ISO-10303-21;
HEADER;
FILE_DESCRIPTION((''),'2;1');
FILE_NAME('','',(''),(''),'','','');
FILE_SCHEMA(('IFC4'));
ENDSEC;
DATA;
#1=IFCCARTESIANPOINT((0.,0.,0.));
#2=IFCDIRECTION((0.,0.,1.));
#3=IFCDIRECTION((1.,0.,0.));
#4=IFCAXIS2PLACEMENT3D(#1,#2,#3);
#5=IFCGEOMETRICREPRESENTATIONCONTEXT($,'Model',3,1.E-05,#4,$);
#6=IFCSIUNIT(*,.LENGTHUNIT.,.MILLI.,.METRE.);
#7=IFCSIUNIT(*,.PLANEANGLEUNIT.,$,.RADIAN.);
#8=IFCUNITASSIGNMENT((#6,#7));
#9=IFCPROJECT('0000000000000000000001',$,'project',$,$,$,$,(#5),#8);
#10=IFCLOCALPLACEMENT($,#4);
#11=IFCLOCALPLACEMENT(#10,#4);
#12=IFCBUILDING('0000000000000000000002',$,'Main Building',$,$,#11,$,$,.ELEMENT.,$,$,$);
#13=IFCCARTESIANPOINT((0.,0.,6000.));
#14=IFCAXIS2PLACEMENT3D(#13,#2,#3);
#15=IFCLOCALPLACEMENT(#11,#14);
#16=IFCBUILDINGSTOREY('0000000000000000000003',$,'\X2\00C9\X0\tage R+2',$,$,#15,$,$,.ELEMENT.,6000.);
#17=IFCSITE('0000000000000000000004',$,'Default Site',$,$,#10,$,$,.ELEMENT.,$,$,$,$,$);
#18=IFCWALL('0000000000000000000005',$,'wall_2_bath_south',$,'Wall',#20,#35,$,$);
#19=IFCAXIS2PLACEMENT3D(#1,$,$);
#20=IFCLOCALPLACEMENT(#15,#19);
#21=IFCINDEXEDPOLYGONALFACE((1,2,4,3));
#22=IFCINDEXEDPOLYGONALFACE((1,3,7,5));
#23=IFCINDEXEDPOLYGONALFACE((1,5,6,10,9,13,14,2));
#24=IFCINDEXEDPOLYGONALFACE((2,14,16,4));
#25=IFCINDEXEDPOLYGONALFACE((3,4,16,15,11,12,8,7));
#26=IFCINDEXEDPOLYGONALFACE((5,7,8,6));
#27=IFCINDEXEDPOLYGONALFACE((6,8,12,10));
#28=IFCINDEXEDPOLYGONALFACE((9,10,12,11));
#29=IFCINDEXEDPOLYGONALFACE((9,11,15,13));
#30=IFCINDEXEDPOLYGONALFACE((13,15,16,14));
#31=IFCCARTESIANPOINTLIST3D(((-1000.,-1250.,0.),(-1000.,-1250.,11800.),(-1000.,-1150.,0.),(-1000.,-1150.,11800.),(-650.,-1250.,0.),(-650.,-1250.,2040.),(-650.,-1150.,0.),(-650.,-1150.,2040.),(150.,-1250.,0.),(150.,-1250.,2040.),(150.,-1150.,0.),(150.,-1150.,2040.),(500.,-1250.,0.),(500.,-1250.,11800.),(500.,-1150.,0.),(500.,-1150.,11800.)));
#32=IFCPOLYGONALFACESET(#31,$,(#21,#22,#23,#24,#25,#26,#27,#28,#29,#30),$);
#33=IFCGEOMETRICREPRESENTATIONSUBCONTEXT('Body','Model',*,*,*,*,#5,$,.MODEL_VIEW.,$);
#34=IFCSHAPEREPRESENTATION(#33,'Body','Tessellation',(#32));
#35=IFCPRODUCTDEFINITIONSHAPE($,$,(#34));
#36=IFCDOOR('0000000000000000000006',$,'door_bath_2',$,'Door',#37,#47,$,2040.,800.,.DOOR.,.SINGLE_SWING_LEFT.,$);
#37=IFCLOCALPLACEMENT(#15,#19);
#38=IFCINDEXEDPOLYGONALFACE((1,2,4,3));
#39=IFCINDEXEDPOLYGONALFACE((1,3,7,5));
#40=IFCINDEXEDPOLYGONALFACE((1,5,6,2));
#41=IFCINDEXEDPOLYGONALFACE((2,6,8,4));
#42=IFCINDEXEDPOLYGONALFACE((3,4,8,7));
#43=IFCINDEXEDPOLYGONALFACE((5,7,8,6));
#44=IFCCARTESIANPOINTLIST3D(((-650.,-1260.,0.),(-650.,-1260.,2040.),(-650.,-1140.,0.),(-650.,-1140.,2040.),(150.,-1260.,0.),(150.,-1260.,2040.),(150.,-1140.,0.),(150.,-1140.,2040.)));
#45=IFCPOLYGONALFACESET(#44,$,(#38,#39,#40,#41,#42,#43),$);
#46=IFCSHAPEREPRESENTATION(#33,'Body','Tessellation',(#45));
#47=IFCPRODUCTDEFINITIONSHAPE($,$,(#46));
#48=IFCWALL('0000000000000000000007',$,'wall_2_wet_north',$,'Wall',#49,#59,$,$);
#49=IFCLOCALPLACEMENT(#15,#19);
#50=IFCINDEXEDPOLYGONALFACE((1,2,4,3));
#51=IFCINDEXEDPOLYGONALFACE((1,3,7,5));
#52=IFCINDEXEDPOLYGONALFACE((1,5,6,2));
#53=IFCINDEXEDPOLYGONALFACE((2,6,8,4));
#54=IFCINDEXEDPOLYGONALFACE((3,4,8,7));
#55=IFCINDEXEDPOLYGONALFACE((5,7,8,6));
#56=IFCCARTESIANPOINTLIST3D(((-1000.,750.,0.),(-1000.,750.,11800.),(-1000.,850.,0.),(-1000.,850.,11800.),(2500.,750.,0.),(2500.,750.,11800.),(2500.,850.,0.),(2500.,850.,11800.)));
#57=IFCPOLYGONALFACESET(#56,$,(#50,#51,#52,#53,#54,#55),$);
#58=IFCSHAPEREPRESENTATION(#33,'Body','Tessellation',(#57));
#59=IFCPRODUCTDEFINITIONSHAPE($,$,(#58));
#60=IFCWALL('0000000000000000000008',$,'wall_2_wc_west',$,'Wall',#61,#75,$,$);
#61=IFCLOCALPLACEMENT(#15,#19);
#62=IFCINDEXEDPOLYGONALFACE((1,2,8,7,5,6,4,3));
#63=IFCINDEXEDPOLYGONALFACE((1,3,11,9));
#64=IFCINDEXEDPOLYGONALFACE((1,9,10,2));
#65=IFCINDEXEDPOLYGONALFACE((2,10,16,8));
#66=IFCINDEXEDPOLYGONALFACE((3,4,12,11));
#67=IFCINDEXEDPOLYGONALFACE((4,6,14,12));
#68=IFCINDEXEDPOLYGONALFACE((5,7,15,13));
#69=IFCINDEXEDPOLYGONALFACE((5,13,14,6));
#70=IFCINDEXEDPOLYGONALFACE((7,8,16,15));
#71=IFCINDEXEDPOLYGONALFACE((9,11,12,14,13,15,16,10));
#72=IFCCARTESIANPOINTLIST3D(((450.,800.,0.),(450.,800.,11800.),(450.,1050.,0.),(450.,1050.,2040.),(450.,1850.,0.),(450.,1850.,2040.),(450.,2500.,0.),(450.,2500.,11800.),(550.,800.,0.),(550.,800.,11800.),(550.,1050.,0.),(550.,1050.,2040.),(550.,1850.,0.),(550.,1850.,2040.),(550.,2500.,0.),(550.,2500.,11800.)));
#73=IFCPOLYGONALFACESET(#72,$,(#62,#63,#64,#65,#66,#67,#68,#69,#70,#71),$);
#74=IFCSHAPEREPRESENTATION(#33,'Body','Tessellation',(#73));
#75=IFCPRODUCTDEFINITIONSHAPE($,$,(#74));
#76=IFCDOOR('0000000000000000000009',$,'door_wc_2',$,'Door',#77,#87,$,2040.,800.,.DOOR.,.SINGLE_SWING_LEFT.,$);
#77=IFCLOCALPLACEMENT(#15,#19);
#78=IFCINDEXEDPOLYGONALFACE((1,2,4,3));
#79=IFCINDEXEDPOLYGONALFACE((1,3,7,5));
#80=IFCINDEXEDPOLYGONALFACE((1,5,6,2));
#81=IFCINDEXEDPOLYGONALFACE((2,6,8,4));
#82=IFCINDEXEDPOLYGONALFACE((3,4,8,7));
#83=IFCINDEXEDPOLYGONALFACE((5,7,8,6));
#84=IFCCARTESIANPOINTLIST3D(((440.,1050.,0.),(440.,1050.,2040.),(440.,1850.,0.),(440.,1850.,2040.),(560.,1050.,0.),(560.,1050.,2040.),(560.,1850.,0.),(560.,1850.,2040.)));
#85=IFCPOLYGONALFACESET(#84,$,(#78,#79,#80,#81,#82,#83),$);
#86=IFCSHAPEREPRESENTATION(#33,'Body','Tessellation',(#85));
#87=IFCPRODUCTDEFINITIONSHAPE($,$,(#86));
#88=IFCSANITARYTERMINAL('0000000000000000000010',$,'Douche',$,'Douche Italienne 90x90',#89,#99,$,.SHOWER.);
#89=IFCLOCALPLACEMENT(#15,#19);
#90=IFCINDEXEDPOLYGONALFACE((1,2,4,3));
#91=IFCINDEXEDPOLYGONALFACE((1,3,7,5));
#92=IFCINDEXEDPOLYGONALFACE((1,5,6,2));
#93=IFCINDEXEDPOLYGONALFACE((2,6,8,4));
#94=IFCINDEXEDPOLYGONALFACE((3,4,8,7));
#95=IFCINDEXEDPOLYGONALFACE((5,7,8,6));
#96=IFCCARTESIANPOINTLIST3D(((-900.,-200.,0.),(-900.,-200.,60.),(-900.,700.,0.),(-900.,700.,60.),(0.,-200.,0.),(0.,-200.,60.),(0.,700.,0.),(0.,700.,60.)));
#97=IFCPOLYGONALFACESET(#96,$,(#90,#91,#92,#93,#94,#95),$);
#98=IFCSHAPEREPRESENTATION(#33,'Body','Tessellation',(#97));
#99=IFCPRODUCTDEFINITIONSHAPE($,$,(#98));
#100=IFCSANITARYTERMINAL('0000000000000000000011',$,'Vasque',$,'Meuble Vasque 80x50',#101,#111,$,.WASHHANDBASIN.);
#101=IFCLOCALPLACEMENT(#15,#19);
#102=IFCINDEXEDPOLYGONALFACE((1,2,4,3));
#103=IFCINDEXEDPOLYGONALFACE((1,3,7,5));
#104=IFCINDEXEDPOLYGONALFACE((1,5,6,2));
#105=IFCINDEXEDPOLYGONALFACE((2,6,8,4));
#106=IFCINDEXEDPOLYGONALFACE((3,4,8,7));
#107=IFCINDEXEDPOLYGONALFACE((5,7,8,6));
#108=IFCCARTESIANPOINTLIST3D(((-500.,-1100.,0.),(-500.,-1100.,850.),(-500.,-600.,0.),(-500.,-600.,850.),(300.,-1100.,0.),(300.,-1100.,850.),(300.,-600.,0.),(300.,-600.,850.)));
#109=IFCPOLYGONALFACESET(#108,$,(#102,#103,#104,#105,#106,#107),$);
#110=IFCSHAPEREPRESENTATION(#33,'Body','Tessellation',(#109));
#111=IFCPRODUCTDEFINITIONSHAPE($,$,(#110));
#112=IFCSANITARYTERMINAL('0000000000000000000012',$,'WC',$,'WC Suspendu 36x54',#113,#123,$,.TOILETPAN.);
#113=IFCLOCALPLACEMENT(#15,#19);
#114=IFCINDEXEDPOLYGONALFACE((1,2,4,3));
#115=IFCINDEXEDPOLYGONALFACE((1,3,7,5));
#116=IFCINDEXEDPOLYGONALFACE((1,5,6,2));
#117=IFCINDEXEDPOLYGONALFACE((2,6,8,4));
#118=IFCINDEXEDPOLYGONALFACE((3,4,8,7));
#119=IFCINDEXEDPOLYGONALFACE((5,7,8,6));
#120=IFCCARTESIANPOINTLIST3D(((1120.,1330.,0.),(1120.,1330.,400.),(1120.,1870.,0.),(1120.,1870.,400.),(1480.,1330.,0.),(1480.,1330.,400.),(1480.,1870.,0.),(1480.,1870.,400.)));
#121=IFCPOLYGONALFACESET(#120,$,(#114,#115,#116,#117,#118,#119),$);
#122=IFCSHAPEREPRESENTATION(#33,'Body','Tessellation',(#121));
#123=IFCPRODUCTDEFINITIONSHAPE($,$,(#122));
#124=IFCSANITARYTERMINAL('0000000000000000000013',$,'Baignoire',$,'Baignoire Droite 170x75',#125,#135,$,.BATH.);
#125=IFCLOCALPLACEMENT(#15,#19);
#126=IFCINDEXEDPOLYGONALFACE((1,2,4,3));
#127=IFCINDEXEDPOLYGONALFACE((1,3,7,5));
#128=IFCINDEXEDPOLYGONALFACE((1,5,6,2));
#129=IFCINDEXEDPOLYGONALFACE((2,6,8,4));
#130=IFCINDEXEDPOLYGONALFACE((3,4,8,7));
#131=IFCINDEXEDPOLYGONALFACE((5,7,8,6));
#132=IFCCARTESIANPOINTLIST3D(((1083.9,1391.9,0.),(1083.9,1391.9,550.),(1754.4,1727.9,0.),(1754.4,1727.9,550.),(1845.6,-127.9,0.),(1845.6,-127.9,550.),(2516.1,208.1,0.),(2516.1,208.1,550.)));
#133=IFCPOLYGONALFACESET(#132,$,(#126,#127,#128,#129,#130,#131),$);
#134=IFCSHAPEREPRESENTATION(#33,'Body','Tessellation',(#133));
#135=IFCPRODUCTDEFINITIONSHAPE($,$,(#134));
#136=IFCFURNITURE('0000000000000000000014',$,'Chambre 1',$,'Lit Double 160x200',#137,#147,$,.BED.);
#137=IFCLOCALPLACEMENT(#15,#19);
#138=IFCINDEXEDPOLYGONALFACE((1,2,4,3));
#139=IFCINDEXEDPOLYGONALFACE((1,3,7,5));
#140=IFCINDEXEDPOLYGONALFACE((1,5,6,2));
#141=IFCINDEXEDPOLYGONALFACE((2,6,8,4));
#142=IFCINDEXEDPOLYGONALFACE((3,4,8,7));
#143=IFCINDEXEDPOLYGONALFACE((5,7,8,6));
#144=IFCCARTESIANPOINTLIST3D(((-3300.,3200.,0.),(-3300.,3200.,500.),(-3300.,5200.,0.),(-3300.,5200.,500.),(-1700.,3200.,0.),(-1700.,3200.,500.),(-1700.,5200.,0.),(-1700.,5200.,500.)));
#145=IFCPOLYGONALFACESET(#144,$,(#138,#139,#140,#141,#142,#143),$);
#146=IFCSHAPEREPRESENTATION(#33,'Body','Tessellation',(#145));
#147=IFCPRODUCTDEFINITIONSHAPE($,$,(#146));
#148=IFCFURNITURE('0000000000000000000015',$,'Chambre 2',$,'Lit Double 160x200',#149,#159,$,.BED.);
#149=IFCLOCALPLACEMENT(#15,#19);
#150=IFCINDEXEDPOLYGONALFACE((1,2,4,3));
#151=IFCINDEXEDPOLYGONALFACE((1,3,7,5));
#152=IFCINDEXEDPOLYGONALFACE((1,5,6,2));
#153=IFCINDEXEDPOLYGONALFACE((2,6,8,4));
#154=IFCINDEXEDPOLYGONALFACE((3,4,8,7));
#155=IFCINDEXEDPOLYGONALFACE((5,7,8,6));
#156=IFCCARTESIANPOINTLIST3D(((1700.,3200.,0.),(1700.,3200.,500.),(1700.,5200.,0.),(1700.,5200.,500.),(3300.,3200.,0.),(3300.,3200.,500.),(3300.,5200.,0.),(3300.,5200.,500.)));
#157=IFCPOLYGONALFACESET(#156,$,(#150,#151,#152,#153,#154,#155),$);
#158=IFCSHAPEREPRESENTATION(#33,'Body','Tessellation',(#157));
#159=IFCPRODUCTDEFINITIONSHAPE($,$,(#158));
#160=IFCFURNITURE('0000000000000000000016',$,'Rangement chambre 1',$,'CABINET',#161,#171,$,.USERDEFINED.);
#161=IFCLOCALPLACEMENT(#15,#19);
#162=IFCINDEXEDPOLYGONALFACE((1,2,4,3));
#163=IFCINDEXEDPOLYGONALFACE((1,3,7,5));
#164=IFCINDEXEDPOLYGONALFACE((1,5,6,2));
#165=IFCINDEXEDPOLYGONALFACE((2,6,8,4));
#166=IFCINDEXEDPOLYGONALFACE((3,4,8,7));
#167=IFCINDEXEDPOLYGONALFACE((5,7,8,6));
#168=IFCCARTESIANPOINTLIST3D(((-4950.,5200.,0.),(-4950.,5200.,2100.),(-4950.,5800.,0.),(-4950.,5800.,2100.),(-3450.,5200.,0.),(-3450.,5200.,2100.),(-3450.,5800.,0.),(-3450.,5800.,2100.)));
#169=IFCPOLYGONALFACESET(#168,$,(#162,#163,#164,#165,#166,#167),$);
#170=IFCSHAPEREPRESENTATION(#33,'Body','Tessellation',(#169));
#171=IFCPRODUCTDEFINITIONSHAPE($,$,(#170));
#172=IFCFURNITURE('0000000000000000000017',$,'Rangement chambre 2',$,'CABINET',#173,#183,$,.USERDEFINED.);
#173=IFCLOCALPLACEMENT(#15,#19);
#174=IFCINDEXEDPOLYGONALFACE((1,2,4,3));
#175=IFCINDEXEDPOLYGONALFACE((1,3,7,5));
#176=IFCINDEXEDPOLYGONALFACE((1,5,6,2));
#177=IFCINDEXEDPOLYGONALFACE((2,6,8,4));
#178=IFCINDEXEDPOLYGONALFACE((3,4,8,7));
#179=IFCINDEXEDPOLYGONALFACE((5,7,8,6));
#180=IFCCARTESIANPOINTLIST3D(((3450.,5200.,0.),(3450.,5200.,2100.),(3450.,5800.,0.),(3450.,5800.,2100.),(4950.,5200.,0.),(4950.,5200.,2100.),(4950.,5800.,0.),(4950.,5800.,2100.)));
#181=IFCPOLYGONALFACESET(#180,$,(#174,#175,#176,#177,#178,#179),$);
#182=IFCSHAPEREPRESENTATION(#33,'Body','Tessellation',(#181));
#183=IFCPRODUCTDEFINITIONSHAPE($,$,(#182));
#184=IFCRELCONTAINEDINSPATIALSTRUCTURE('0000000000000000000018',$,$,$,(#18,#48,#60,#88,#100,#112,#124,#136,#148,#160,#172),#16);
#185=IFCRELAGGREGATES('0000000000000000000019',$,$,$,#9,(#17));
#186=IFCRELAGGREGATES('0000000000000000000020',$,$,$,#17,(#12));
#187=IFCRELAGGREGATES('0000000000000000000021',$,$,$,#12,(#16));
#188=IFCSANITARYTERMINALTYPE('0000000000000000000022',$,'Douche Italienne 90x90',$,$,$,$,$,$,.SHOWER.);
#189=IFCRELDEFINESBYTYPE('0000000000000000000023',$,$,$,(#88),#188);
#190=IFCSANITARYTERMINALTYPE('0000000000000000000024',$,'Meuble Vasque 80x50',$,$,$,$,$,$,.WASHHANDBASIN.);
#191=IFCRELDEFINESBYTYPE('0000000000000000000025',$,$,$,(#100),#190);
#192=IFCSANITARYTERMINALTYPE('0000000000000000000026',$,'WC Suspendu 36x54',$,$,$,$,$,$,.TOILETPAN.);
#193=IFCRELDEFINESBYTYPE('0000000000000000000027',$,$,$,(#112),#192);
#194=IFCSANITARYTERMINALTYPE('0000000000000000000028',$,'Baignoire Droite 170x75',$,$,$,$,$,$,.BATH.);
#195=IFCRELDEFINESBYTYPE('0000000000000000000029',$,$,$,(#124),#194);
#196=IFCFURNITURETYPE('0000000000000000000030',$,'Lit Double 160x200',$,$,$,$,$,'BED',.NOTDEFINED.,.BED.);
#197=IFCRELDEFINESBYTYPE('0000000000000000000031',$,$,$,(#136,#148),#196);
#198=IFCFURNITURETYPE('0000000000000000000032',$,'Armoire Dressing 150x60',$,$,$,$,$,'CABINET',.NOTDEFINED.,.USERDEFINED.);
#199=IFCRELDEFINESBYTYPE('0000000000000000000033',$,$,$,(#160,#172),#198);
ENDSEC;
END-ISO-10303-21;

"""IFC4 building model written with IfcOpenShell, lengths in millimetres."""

from ifc_helpers import new_model, si_unit, frame, origin_with_axes, place, context, subcontext, project, spatial, polyline, outline, extrude, type_object, element, fill, save


model = new_model("IFC4")

# Units and contexts
model_context = context("Model", 3, precision=1e-05, world=origin_with_axes())
body_context = subcontext(model_context, "Body", "Model", "MODEL_VIEW")
ifc_project = project(units=[si_unit("LENGTHUNIT", "METRE", prefix="MILLI"), si_unit("PLANEANGLEUNIT", "RADIAN")], contexts=[model_context])

# Site, building, storey
site_placement = place(None, origin_with_axes())
site = spatial("IfcSite", under=ifc_project, at=site_placement, Name="Default Site", CompositionType="ELEMENT")
building_placement = place(site_placement, origin_with_axes())
building = spatial("IfcBuilding", under=site, at=building_placement, Name="Main Building", CompositionType="ELEMENT")
storey_placement = place(building_placement, frame((0.0, 0.0, 6000.0), z_axis=(0.0, 0.0, 1.0), x_axis=(1.0, 0.0, 0.0)))
storey = spatial("IfcBuildingStorey", under=building, at=storey_placement, Name="Étage R+2", CompositionType="ELEMENT", Elevation=6000.0)

# Wall, opening, door
wall_1_placement = place(storey_placement, frame((-1000.0, -1200.0, 0.0), z_axis=(0.0, 0.0, 1.0), x_axis=(1.0, 0.0, 0.0)))
wall_1 = element("IfcWall", 1, at=wall_1_placement, inside=storey, Name="wall_2_bath_south", ObjectType="Wall", context=body_context, shape_type="SweptSolid", body=[
    extrude(outline(polyline([(0.0, -50.0), (1500.0, -50.0), (1500.0, 50.0), (0.0, 50.0), (0.0, -50.0)])), origin_with_axes(), (0.0, 0.0, 1.0), 11800.0),
])
placement_1 = place(wall_1_placement, frame((350.0, 0.0, 0.0), z_axis=(0.0, 0.0, 1.0), x_axis=(1.0, 0.0, 0.0)))
opening_1 = element("IfcOpeningElement", 2, at=placement_1, cuts=wall_1, PredefinedType="OPENING", context=body_context, shape_type="SweptSolid", body=[
    extrude(outline(polyline([(0.0, -60.0), (800.0, -60.0), (800.0, 60.0), (0.0, 60.0), (0.0, -60.0)])), origin_with_axes(), (0.0, 0.0, 1.0), 2040.0),
])
door_1 = element("IfcDoor", 3, at=placement_1, Name="door_bath_2", ObjectType="Door", OperationType="SINGLE_SWING_LEFT", OverallHeight=2040.0, OverallWidth=800.0, PredefinedType="DOOR", context=body_context, shape_type="SweptSolid", body=[
    extrude(outline(polyline([(0.0, -60.0), (800.0, -60.0), (800.0, 60.0), (0.0, 60.0), (0.0, -60.0)])), origin_with_axes(), (0.0, 0.0, 1.0), 2040.0),
])
fill(opening_1, door_1)

# Wall
wall_2_placement = place(storey_placement, frame((-1000.0, 800.0, 0.0), z_axis=(0.0, 0.0, 1.0), x_axis=(1.0, 0.0, 0.0)))
element("IfcWall", 4, at=wall_2_placement, inside=storey, Name="wall_2_wet_north", ObjectType="Wall", context=body_context, shape_type="SweptSolid", body=[
    extrude(outline(polyline([(0.0, -50.0), (3500.0, -50.0), (3500.0, 50.0), (0.0, 50.0), (0.0, -50.0)])), origin_with_axes(), (0.0, 0.0, 1.0), 11800.0),
])

# Wall, opening, door
wall_3_placement = place(storey_placement, frame((500.0, 800.0, 0.0), z_axis=(0.0, 0.0, 1.0), x_axis=(0.0, 1.0, 0.0)))
wall_3 = element("IfcWall", 5, at=wall_3_placement, inside=storey, Name="wall_2_wc_west", ObjectType="Wall", context=body_context, shape_type="SweptSolid", body=[
    extrude(outline(polyline([(0.0, -50.0), (1700.0, -50.0), (1700.0, 50.0), (0.0, 50.0), (0.0, -50.0)])), origin_with_axes(), (0.0, 0.0, 1.0), 11800.0),
])
placement_2 = place(wall_3_placement, frame((250.0, 0.0, 0.0), z_axis=(0.0, 0.0, 1.0), x_axis=(1.0, 0.0, 0.0)))
opening_2 = element("IfcOpeningElement", 6, at=placement_2, cuts=wall_3, PredefinedType="OPENING", context=body_context, shape_type="SweptSolid", body=[
    extrude(outline(polyline([(0.0, -60.0), (800.0, -60.0), (800.0, 60.0), (0.0, 60.0), (0.0, -60.0)])), origin_with_axes(), (0.0, 0.0, 1.0), 2040.0),
])
door_2 = element("IfcDoor", 7, at=placement_2, Name="door_wc_2", ObjectType="Door", OperationType="SINGLE_SWING_LEFT", OverallHeight=2040.0, OverallWidth=800.0, PredefinedType="DOOR", context=body_context, shape_type="SweptSolid", body=[
    extrude(outline(polyline([(0.0, -60.0), (800.0, -60.0), (800.0, 60.0), (0.0, 60.0), (0.0, -60.0)])), origin_with_axes(), (0.0, 0.0, 1.0), 2040.0),
])
fill(opening_2, door_2)

# Sanitary terminals
sanitary_terminal_type_1 = type_object("IfcSanitaryTerminalType", Name="Douche Italienne 90x90", PredefinedType="SHOWER")
sanitary_terminal_1_placement = place(storey_placement, frame((-450.0, 250.0, 0.0), z_axis=(0.0, 0.0, 1.0), x_axis=(1.0, 0.0, 0.0)))
element("IfcSanitaryTerminal", 8, at=sanitary_terminal_1_placement, inside=storey, type_object=sanitary_terminal_type_1, Name="Douche", ObjectType="Douche Italienne 90x90", PredefinedType="SHOWER", context=body_context, shape_type="SweptSolid", body=[
    extrude(outline(polyline([(-450.0, -450.0), (450.0, -450.0), (450.0, 450.0), (-450.0, 450.0), (-450.0, -450.0)])), origin_with_axes(), (0.0, 0.0, 1.0), 60.0),
])
sanitary_terminal_type_2 = type_object("IfcSanitaryTerminalType", Name="Meuble Vasque 80x50", PredefinedType="WASHHANDBASIN")
sanitary_terminal_2_placement = place(storey_placement, frame((-100.0, -850.0, 0.0), z_axis=(0.0, 0.0, 1.0), x_axis=(1.0, 0.0, 0.0)))
element("IfcSanitaryTerminal", 9, at=sanitary_terminal_2_placement, inside=storey, type_object=sanitary_terminal_type_2, Name="Vasque", ObjectType="Meuble Vasque 80x50", PredefinedType="WASHHANDBASIN", context=body_context, shape_type="SweptSolid", body=[
    extrude(outline(polyline([(-400.0, -250.0), (400.0, -250.0), (400.0, 250.0), (-400.0, 250.0), (-400.0, -250.0)])), origin_with_axes(), (0.0, 0.0, 1.0), 850.0),
])
sanitary_terminal_type_3 = type_object("IfcSanitaryTerminalType", Name="WC Suspendu 36x54", PredefinedType="TOILETPAN")
sanitary_terminal_3_placement = place(storey_placement, frame((1300.0, 1600.0, 0.0), z_axis=(0.0, 0.0, 1.0), x_axis=(1.0, 0.0, 0.0)))
element("IfcSanitaryTerminal", 10, at=sanitary_terminal_3_placement, inside=storey, type_object=sanitary_terminal_type_3, Name="WC", ObjectType="WC Suspendu 36x54", PredefinedType="TOILETPAN", context=body_context, shape_type="SweptSolid", body=[
    extrude(outline(polyline([(-180.0, -270.0), (180.0, -270.0), (180.0, 270.0), (-180.0, 270.0), (-180.0, -270.0)])), origin_with_axes(), (0.0, 0.0, 1.0), 400.0),
])
sanitary_terminal_type_4 = type_object("IfcSanitaryTerminalType", Name="Baignoire Droite 170x75", PredefinedType="BATH")
sanitary_terminal_4_placement = place(storey_placement, frame((1800.0, 800.0, 0.0), z_axis=(0.0, 0.0, 1.0), x_axis=(-0.448074, 0.893997, 0.0)))
element("IfcSanitaryTerminal", 11, at=sanitary_terminal_4_placement, inside=storey, type_object=sanitary_terminal_type_4, Name="Baignoire", ObjectType="Baignoire Droite 170x75", PredefinedType="BATH", context=body_context, shape_type="SweptSolid", body=[
    extrude(outline(polyline([(-850.0, -375.0), (850.0, -375.0), (850.0, 375.0), (-850.0, 375.0), (-850.0, -375.0)])), origin_with_axes(), (0.0, 0.0, 1.0), 550.0),
])

# Furniture
furniture_type_1 = type_object("IfcFurnitureType", Name="Lit Double 160x200", ElementType="BED", AssemblyPlace="NOTDEFINED", PredefinedType="BED")
for number, where, z_axis, x_axis, name in (
    (12, (-2500.0, 4200.0, 0.0), (0.0, 0.0, 1.0), (1.0, 0.0, 0.0), "Chambre 1"),
    (13, (2500.0, 4200.0, 0.0), (0.0, 0.0, 1.0), (1.0, 0.0, 0.0), "Chambre 2"),
):
    element("IfcFurniture", number, at=place(storey_placement, frame(where, z_axis=z_axis, x_axis=x_axis)), inside=storey, type_object=furniture_type_1, Name=name, ObjectType="Lit Double 160x200", PredefinedType="BED", context=body_context, shape_type="SweptSolid", body=[
        extrude(outline(polyline([(-800.0, -1000.0), (800.0, -1000.0), (800.0, 1000.0), (-800.0, 1000.0), (-800.0, -1000.0)])), origin_with_axes(), (0.0, 0.0, 1.0), 500.0),
    ])
furniture_type_2 = type_object("IfcFurnitureType", Name="Armoire Dressing 150x60", ElementType="CABINET", AssemblyPlace="NOTDEFINED", PredefinedType="USERDEFINED")
for number, where, z_axis, x_axis, name in (
    (14, (-4200.0, 5500.0, 0.0), (0.0, 0.0, 1.0), (1.0, 0.0, 0.0), "Rangement chambre 1"),
    (15, (4200.0, 5500.0, 0.0), (0.0, 0.0, 1.0), (1.0, 0.0, 0.0), "Rangement chambre 2"),
):
    element("IfcFurniture", number, at=place(storey_placement, frame(where, z_axis=z_axis, x_axis=x_axis)), inside=storey, type_object=furniture_type_2, Name=name, ObjectType="CABINET", PredefinedType="USERDEFINED", context=body_context, shape_type="SweptSolid", body=[
        extrude(outline(polyline([(-750.0, -300.0), (750.0, -300.0), (750.0, 300.0), (-750.0, 300.0), (-750.0, -300.0)])), origin_with_axes(), (0.0, 0.0, 1.0), 2100.0),
    ])

save(model, "model.ifc")
